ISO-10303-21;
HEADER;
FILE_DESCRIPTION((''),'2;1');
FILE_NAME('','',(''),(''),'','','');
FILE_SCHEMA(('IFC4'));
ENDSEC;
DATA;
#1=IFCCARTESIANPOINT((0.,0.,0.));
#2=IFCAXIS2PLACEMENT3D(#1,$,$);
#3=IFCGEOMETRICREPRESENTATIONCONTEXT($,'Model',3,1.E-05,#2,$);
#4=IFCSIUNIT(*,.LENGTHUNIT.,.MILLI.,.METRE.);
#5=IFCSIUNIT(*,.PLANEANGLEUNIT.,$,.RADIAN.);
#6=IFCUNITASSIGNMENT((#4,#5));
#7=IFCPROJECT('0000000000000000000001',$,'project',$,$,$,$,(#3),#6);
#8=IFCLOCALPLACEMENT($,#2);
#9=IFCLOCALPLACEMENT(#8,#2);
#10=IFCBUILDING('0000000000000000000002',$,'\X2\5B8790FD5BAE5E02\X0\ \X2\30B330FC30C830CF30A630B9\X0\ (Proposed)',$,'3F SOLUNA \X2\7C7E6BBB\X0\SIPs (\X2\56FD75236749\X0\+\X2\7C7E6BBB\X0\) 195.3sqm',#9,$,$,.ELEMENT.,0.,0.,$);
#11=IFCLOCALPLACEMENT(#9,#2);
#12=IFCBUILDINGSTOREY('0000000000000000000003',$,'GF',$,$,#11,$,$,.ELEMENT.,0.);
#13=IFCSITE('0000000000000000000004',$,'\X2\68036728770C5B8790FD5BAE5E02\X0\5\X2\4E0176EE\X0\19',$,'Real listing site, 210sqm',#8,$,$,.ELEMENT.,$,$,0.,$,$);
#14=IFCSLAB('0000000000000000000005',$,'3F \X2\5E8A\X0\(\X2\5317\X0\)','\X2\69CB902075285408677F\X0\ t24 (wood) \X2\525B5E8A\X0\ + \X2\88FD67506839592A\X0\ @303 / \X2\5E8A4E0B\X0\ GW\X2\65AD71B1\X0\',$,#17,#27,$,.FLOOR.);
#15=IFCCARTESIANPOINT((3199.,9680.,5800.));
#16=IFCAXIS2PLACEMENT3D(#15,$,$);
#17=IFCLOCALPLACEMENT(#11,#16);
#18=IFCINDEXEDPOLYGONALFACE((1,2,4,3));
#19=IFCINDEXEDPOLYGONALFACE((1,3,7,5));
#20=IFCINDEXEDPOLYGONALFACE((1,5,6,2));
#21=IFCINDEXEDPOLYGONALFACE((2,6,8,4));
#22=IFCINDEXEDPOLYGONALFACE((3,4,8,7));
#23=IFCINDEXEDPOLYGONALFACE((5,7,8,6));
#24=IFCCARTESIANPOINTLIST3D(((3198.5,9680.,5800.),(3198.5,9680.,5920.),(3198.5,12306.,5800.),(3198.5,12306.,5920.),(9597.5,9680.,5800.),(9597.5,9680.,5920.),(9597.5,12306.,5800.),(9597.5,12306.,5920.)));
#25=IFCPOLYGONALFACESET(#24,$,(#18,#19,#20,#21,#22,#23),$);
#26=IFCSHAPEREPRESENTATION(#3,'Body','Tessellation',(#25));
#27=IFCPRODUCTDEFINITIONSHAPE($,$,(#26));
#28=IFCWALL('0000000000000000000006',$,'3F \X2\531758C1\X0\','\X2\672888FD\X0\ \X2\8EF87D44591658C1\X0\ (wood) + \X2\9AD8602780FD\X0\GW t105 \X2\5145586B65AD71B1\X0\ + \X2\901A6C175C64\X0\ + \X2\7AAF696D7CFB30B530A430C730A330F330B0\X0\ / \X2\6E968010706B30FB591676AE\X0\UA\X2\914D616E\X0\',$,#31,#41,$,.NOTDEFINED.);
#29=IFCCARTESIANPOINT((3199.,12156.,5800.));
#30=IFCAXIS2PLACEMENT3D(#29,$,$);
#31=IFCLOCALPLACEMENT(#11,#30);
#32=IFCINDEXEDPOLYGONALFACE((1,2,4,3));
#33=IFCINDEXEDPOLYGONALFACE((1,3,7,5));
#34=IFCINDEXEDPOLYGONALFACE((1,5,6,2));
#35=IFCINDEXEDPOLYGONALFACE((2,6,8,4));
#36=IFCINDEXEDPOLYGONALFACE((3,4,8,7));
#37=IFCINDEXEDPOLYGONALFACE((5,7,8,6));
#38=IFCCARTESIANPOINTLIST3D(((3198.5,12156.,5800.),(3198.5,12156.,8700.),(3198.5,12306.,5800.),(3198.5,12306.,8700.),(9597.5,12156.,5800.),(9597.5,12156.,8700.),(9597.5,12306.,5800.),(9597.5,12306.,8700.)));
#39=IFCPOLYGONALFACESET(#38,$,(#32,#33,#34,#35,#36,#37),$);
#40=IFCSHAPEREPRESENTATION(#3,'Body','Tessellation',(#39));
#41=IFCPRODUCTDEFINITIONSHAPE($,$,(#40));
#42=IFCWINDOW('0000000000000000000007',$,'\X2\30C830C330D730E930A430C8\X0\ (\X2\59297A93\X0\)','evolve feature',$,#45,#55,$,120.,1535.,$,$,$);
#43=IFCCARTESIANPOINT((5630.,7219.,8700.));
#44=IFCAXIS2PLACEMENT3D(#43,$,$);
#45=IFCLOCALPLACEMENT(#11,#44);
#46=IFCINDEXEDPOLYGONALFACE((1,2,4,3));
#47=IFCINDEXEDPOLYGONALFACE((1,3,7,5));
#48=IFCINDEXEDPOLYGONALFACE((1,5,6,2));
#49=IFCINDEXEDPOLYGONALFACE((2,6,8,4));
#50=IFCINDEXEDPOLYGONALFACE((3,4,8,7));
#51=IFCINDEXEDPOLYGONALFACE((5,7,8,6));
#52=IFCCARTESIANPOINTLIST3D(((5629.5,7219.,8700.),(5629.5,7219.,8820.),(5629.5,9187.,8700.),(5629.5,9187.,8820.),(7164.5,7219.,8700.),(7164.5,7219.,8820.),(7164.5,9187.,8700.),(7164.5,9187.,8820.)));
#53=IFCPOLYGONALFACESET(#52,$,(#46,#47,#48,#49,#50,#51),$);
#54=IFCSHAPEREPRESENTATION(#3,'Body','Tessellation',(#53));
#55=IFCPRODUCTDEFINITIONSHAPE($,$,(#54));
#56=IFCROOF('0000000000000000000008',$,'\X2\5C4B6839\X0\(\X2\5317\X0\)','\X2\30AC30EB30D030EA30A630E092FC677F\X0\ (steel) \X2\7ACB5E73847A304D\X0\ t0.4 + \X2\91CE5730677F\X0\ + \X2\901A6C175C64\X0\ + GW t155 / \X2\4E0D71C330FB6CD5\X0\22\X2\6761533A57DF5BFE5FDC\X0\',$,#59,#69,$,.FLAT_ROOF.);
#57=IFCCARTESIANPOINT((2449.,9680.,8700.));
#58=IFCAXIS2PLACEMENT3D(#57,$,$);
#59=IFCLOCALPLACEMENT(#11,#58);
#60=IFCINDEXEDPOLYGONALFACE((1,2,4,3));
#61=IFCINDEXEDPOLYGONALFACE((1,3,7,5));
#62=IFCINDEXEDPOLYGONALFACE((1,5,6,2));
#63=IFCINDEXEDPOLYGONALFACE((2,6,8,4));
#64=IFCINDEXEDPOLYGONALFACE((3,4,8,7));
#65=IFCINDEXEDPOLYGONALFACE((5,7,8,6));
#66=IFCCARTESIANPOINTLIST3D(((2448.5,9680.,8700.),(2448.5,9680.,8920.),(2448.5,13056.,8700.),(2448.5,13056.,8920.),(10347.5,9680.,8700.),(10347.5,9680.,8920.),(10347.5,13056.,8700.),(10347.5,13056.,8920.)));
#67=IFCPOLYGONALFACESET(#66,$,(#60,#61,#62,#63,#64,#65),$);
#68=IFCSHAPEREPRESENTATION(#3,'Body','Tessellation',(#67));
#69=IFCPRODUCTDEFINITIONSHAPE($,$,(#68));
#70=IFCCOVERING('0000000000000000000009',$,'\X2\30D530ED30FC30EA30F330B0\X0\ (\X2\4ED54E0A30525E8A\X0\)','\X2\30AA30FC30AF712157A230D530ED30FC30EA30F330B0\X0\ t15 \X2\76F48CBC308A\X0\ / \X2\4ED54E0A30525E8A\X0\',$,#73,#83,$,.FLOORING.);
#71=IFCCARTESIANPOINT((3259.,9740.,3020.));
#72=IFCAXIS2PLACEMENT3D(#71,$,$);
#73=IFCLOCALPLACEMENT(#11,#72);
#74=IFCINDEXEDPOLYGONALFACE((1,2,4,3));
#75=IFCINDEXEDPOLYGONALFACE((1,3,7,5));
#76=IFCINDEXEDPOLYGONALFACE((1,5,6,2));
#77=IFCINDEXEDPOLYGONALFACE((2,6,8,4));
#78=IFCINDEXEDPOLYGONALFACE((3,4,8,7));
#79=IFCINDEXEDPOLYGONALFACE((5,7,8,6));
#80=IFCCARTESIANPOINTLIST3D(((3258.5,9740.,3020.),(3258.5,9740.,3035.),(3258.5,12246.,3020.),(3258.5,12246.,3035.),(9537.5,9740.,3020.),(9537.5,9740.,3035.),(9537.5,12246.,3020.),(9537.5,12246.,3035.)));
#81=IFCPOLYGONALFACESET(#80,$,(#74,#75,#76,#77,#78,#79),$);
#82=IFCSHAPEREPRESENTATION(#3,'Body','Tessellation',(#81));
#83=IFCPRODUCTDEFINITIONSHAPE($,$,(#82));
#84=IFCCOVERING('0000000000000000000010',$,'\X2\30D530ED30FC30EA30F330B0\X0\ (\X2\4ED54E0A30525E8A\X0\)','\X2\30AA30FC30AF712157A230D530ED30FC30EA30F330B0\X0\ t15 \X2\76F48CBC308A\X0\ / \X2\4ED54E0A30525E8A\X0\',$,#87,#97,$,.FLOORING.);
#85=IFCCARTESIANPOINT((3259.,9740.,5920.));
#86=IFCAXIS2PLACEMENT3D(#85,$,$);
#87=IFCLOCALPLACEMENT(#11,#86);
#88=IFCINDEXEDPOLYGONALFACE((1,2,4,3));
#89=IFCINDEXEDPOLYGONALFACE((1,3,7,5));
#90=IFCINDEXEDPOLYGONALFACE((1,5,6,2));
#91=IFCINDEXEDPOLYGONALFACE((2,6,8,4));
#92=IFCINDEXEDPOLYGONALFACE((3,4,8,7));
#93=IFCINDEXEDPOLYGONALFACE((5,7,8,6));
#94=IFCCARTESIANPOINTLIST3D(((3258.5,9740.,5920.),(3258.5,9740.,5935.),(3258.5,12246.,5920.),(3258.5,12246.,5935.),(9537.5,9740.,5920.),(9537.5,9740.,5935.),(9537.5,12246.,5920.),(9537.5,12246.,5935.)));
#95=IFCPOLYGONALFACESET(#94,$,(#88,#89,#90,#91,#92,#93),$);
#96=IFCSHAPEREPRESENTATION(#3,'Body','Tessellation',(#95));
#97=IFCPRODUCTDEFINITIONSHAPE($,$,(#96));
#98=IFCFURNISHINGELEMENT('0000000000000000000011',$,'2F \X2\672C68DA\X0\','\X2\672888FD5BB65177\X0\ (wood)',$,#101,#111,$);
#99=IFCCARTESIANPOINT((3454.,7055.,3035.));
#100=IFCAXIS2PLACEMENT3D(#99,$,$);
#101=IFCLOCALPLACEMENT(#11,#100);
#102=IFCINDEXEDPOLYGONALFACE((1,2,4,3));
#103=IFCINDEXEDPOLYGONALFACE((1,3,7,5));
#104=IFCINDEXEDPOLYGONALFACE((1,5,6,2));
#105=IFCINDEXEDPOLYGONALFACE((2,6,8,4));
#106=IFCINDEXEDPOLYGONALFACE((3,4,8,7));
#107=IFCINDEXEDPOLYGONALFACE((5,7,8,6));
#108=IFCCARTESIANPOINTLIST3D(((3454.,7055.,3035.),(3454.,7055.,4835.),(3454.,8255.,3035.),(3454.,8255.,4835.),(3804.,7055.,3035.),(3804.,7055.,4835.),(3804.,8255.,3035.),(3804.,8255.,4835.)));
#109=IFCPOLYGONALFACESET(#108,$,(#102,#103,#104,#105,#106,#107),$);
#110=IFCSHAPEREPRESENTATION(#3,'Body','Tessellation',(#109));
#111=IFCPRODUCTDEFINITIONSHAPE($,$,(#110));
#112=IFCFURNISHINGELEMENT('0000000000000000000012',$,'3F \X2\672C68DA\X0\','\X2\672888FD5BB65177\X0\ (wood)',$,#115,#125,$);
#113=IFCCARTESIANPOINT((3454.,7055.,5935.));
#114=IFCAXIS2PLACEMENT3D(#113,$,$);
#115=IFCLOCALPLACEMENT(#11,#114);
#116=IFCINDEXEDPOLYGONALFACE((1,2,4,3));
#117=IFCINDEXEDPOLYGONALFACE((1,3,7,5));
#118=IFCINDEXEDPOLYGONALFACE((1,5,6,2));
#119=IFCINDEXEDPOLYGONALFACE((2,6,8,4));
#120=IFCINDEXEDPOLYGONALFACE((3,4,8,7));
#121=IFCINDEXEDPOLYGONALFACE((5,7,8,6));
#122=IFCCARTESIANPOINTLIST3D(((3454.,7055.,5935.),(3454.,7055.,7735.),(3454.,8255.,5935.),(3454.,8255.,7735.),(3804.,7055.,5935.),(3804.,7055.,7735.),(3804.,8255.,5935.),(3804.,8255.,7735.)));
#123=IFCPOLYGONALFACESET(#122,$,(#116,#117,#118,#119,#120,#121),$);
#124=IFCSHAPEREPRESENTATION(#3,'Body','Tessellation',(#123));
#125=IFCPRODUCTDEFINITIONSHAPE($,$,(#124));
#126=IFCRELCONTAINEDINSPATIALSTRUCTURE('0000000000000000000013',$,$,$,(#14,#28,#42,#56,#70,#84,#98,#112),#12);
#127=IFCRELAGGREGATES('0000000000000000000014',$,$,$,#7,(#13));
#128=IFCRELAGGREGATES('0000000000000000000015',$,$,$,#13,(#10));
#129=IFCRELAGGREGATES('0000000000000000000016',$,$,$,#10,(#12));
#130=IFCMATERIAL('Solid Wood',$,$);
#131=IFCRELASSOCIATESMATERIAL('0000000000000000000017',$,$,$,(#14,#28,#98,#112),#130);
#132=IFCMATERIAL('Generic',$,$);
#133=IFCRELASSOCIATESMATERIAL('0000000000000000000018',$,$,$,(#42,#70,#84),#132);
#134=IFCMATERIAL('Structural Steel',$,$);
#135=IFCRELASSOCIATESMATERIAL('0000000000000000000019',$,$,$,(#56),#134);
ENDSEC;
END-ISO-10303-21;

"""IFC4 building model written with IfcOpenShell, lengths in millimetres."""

from ifc_helpers import new_model, si_unit, frame, frame_2d, origin, place, context, project, spatial, rectangle, extrude, material, element, save


model = new_model("IFC4")

# Units and contexts
model_context = context("Model", 3, precision=1e-05, world=origin())
ifc_project = project(units=[si_unit("LENGTHUNIT", "METRE", prefix="MILLI"), si_unit("PLANEANGLEUNIT", "RADIAN")], contexts=[model_context])

# Site, building, storey
site_placement = place(None, origin())
site = spatial("IfcSite", under=ifc_project, at=site_placement, Name="栃木県宇都宮市5丁目19", ObjectType="Real listing site, 210sqm", CompositionType="ELEMENT", RefElevation=0.0)
building_placement = place(site_placement, origin())
building = spatial("IfcBuilding", under=site, at=building_placement, Name="宇都宮市 コートハウス (Proposed)", ObjectType="3F SOLUNA 籾殻SIPs (国産杉+籾殻) 195.3sqm", CompositionType="ELEMENT", ElevationOfRefHeight=0.0, ElevationOfTerrain=0.0)
storey_placement = place(building_placement, origin())
storey = spatial("IfcBuildingStorey", under=building, at=storey_placement, Name="GF", CompositionType="ELEMENT", Elevation=0.0)

# Slab
ifc_material_1 = material(Name="Solid Wood")
slab_placement = place(storey_placement, frame((3199.0, 9680.0, 5800.0)))
element("IfcSlab", 1, at=slab_placement, inside=storey, material=ifc_material_1, Name="3F 床(北)", Description="構造用合板 t24 (wood) 剛床 + 製材根太 @303 / 床下 GW断熱", PredefinedType="FLOOR", context=model_context, shape_type="SweptSolid", body=[
    extrude(rectangle(XDim=6399.0, YDim=2626.0, at=frame_2d((3199.0, 1313.0))), frame((3199.0, 9680.0, 5800.0)), (0.0, 0.0, 1.0), 120.0),
])

# Wall
wall_1_placement = place(storey_placement, frame((3199.0, 12156.0, 5800.0)))
element("IfcWall", 2, at=wall_1_placement, inside=storey, material=ifc_material_1, Name="3F 北壁", Description="木製 軸組外壁 (wood) + 高性能GW t105 充填断熱 + 通気層 + 窯業系サイディング / 準耐火・外皮UA配慮", PredefinedType="NOTDEFINED", context=model_context, shape_type="SweptSolid", body=[
    extrude(rectangle(XDim=6399.0, YDim=150.0, at=frame_2d((3199.0, 75.0))), frame((3199.0, 12156.0, 5800.0)), (0.0, 0.0, 1.0), 2900.0),
])

# Window
ifc_material_2 = material(Name="Generic")
window_1_placement = place(storey_placement, frame((5630.0, 7219.0, 8700.0)))
element("IfcWindow", 3, at=window_1_placement, inside=storey, material=ifc_material_2, Name="トップライト (天窓)", Description="evolve feature", OverallHeight=120.0, OverallWidth=1535.0, context=model_context, shape_type="SweptSolid", body=[
    extrude(rectangle(XDim=1535.0, YDim=1968.0, at=frame_2d((767.0, 984.0))), frame((5630.0, 7219.0, 8700.0)), (0.0, 0.0, 1.0), 120.0),
])

# Roof
ifc_material_3 = material(Name="Structural Steel")
roof_1_placement = place(storey_placement, frame((2449.0, 9680.0, 8700.0)))
element("IfcRoof", 4, at=roof_1_placement, inside=storey, material=ifc_material_3, Name="屋根(北)", Description="ガルバリウム鋼板 (steel) 立平葺き t0.4 + 野地板 + 通気層 + GW t155 / 不燃・法22条区域対応", PredefinedType="FLAT_ROOF", context=model_context, shape_type="SweptSolid", body=[
    extrude(rectangle(XDim=7899.0, YDim=3376.0, at=frame_2d((3949.0, 1688.0))), frame((2449.0, 9680.0, 8700.0)), (0.0, 0.0, 1.0), 220.0),
])

# Coverings
covering_1_placement = place(storey_placement, frame((3259.0, 9740.0, 3020.0)))
element("IfcCovering", 5, at=covering_1_placement, inside=storey, material=ifc_material_2, Name="フローリング (仕上げ床)", Description="オーク無垢フローリング t15 直貼り / 仕上げ床", PredefinedType="FLOORING", context=model_context, shape_type="SweptSolid", body=[
    extrude(rectangle(XDim=6279.0, YDim=2506.0, at=frame_2d((3139.0, 1253.0))), frame((3259.0, 9740.0, 3020.0)), (0.0, 0.0, 1.0), 15.0),
])
covering_2_placement = place(storey_placement, frame((3259.0, 9740.0, 5920.0)))
element("IfcCovering", 6, at=covering_2_placement, inside=storey, material=ifc_material_2, Name="フローリング (仕上げ床)", Description="オーク無垢フローリング t15 直貼り / 仕上げ床", PredefinedType="FLOORING", context=model_context, shape_type="SweptSolid", body=[
    extrude(rectangle(XDim=6279.0, YDim=2506.0, at=frame_2d((3139.0, 1253.0))), frame((3259.0, 9740.0, 5920.0)), (0.0, 0.0, 1.0), 15.0),
])

# Furnishing elements
furnishing_1_placement = place(storey_placement, frame((3454.0, 7055.0, 3035.0)))
element("IfcFurnishingElement", 7, at=furnishing_1_placement, inside=storey, material=ifc_material_1, Name="2F 本棚", Description="木製家具 (wood)", context=model_context, shape_type="SweptSolid", body=[
    extrude(rectangle(XDim=350.0, YDim=1200.0, at=frame_2d((175.0, 600.0))), frame((3454.0, 7055.0, 3035.0)), (0.0, 0.0, 1.0), 1800.0),
])
furnishing_2_placement = place(storey_placement, frame((3454.0, 7055.0, 5935.0)))
element("IfcFurnishingElement", 8, at=furnishing_2_placement, inside=storey, material=ifc_material_1, Name="3F 本棚", Description="木製家具 (wood)", context=model_context, shape_type="SweptSolid", body=[
    extrude(rectangle(XDim=350.0, YDim=1200.0, at=frame_2d((175.0, 600.0))), frame((3454.0, 7055.0, 5935.0)), (0.0, 0.0, 1.0), 1800.0),
])

save(model, "model.ifc")
